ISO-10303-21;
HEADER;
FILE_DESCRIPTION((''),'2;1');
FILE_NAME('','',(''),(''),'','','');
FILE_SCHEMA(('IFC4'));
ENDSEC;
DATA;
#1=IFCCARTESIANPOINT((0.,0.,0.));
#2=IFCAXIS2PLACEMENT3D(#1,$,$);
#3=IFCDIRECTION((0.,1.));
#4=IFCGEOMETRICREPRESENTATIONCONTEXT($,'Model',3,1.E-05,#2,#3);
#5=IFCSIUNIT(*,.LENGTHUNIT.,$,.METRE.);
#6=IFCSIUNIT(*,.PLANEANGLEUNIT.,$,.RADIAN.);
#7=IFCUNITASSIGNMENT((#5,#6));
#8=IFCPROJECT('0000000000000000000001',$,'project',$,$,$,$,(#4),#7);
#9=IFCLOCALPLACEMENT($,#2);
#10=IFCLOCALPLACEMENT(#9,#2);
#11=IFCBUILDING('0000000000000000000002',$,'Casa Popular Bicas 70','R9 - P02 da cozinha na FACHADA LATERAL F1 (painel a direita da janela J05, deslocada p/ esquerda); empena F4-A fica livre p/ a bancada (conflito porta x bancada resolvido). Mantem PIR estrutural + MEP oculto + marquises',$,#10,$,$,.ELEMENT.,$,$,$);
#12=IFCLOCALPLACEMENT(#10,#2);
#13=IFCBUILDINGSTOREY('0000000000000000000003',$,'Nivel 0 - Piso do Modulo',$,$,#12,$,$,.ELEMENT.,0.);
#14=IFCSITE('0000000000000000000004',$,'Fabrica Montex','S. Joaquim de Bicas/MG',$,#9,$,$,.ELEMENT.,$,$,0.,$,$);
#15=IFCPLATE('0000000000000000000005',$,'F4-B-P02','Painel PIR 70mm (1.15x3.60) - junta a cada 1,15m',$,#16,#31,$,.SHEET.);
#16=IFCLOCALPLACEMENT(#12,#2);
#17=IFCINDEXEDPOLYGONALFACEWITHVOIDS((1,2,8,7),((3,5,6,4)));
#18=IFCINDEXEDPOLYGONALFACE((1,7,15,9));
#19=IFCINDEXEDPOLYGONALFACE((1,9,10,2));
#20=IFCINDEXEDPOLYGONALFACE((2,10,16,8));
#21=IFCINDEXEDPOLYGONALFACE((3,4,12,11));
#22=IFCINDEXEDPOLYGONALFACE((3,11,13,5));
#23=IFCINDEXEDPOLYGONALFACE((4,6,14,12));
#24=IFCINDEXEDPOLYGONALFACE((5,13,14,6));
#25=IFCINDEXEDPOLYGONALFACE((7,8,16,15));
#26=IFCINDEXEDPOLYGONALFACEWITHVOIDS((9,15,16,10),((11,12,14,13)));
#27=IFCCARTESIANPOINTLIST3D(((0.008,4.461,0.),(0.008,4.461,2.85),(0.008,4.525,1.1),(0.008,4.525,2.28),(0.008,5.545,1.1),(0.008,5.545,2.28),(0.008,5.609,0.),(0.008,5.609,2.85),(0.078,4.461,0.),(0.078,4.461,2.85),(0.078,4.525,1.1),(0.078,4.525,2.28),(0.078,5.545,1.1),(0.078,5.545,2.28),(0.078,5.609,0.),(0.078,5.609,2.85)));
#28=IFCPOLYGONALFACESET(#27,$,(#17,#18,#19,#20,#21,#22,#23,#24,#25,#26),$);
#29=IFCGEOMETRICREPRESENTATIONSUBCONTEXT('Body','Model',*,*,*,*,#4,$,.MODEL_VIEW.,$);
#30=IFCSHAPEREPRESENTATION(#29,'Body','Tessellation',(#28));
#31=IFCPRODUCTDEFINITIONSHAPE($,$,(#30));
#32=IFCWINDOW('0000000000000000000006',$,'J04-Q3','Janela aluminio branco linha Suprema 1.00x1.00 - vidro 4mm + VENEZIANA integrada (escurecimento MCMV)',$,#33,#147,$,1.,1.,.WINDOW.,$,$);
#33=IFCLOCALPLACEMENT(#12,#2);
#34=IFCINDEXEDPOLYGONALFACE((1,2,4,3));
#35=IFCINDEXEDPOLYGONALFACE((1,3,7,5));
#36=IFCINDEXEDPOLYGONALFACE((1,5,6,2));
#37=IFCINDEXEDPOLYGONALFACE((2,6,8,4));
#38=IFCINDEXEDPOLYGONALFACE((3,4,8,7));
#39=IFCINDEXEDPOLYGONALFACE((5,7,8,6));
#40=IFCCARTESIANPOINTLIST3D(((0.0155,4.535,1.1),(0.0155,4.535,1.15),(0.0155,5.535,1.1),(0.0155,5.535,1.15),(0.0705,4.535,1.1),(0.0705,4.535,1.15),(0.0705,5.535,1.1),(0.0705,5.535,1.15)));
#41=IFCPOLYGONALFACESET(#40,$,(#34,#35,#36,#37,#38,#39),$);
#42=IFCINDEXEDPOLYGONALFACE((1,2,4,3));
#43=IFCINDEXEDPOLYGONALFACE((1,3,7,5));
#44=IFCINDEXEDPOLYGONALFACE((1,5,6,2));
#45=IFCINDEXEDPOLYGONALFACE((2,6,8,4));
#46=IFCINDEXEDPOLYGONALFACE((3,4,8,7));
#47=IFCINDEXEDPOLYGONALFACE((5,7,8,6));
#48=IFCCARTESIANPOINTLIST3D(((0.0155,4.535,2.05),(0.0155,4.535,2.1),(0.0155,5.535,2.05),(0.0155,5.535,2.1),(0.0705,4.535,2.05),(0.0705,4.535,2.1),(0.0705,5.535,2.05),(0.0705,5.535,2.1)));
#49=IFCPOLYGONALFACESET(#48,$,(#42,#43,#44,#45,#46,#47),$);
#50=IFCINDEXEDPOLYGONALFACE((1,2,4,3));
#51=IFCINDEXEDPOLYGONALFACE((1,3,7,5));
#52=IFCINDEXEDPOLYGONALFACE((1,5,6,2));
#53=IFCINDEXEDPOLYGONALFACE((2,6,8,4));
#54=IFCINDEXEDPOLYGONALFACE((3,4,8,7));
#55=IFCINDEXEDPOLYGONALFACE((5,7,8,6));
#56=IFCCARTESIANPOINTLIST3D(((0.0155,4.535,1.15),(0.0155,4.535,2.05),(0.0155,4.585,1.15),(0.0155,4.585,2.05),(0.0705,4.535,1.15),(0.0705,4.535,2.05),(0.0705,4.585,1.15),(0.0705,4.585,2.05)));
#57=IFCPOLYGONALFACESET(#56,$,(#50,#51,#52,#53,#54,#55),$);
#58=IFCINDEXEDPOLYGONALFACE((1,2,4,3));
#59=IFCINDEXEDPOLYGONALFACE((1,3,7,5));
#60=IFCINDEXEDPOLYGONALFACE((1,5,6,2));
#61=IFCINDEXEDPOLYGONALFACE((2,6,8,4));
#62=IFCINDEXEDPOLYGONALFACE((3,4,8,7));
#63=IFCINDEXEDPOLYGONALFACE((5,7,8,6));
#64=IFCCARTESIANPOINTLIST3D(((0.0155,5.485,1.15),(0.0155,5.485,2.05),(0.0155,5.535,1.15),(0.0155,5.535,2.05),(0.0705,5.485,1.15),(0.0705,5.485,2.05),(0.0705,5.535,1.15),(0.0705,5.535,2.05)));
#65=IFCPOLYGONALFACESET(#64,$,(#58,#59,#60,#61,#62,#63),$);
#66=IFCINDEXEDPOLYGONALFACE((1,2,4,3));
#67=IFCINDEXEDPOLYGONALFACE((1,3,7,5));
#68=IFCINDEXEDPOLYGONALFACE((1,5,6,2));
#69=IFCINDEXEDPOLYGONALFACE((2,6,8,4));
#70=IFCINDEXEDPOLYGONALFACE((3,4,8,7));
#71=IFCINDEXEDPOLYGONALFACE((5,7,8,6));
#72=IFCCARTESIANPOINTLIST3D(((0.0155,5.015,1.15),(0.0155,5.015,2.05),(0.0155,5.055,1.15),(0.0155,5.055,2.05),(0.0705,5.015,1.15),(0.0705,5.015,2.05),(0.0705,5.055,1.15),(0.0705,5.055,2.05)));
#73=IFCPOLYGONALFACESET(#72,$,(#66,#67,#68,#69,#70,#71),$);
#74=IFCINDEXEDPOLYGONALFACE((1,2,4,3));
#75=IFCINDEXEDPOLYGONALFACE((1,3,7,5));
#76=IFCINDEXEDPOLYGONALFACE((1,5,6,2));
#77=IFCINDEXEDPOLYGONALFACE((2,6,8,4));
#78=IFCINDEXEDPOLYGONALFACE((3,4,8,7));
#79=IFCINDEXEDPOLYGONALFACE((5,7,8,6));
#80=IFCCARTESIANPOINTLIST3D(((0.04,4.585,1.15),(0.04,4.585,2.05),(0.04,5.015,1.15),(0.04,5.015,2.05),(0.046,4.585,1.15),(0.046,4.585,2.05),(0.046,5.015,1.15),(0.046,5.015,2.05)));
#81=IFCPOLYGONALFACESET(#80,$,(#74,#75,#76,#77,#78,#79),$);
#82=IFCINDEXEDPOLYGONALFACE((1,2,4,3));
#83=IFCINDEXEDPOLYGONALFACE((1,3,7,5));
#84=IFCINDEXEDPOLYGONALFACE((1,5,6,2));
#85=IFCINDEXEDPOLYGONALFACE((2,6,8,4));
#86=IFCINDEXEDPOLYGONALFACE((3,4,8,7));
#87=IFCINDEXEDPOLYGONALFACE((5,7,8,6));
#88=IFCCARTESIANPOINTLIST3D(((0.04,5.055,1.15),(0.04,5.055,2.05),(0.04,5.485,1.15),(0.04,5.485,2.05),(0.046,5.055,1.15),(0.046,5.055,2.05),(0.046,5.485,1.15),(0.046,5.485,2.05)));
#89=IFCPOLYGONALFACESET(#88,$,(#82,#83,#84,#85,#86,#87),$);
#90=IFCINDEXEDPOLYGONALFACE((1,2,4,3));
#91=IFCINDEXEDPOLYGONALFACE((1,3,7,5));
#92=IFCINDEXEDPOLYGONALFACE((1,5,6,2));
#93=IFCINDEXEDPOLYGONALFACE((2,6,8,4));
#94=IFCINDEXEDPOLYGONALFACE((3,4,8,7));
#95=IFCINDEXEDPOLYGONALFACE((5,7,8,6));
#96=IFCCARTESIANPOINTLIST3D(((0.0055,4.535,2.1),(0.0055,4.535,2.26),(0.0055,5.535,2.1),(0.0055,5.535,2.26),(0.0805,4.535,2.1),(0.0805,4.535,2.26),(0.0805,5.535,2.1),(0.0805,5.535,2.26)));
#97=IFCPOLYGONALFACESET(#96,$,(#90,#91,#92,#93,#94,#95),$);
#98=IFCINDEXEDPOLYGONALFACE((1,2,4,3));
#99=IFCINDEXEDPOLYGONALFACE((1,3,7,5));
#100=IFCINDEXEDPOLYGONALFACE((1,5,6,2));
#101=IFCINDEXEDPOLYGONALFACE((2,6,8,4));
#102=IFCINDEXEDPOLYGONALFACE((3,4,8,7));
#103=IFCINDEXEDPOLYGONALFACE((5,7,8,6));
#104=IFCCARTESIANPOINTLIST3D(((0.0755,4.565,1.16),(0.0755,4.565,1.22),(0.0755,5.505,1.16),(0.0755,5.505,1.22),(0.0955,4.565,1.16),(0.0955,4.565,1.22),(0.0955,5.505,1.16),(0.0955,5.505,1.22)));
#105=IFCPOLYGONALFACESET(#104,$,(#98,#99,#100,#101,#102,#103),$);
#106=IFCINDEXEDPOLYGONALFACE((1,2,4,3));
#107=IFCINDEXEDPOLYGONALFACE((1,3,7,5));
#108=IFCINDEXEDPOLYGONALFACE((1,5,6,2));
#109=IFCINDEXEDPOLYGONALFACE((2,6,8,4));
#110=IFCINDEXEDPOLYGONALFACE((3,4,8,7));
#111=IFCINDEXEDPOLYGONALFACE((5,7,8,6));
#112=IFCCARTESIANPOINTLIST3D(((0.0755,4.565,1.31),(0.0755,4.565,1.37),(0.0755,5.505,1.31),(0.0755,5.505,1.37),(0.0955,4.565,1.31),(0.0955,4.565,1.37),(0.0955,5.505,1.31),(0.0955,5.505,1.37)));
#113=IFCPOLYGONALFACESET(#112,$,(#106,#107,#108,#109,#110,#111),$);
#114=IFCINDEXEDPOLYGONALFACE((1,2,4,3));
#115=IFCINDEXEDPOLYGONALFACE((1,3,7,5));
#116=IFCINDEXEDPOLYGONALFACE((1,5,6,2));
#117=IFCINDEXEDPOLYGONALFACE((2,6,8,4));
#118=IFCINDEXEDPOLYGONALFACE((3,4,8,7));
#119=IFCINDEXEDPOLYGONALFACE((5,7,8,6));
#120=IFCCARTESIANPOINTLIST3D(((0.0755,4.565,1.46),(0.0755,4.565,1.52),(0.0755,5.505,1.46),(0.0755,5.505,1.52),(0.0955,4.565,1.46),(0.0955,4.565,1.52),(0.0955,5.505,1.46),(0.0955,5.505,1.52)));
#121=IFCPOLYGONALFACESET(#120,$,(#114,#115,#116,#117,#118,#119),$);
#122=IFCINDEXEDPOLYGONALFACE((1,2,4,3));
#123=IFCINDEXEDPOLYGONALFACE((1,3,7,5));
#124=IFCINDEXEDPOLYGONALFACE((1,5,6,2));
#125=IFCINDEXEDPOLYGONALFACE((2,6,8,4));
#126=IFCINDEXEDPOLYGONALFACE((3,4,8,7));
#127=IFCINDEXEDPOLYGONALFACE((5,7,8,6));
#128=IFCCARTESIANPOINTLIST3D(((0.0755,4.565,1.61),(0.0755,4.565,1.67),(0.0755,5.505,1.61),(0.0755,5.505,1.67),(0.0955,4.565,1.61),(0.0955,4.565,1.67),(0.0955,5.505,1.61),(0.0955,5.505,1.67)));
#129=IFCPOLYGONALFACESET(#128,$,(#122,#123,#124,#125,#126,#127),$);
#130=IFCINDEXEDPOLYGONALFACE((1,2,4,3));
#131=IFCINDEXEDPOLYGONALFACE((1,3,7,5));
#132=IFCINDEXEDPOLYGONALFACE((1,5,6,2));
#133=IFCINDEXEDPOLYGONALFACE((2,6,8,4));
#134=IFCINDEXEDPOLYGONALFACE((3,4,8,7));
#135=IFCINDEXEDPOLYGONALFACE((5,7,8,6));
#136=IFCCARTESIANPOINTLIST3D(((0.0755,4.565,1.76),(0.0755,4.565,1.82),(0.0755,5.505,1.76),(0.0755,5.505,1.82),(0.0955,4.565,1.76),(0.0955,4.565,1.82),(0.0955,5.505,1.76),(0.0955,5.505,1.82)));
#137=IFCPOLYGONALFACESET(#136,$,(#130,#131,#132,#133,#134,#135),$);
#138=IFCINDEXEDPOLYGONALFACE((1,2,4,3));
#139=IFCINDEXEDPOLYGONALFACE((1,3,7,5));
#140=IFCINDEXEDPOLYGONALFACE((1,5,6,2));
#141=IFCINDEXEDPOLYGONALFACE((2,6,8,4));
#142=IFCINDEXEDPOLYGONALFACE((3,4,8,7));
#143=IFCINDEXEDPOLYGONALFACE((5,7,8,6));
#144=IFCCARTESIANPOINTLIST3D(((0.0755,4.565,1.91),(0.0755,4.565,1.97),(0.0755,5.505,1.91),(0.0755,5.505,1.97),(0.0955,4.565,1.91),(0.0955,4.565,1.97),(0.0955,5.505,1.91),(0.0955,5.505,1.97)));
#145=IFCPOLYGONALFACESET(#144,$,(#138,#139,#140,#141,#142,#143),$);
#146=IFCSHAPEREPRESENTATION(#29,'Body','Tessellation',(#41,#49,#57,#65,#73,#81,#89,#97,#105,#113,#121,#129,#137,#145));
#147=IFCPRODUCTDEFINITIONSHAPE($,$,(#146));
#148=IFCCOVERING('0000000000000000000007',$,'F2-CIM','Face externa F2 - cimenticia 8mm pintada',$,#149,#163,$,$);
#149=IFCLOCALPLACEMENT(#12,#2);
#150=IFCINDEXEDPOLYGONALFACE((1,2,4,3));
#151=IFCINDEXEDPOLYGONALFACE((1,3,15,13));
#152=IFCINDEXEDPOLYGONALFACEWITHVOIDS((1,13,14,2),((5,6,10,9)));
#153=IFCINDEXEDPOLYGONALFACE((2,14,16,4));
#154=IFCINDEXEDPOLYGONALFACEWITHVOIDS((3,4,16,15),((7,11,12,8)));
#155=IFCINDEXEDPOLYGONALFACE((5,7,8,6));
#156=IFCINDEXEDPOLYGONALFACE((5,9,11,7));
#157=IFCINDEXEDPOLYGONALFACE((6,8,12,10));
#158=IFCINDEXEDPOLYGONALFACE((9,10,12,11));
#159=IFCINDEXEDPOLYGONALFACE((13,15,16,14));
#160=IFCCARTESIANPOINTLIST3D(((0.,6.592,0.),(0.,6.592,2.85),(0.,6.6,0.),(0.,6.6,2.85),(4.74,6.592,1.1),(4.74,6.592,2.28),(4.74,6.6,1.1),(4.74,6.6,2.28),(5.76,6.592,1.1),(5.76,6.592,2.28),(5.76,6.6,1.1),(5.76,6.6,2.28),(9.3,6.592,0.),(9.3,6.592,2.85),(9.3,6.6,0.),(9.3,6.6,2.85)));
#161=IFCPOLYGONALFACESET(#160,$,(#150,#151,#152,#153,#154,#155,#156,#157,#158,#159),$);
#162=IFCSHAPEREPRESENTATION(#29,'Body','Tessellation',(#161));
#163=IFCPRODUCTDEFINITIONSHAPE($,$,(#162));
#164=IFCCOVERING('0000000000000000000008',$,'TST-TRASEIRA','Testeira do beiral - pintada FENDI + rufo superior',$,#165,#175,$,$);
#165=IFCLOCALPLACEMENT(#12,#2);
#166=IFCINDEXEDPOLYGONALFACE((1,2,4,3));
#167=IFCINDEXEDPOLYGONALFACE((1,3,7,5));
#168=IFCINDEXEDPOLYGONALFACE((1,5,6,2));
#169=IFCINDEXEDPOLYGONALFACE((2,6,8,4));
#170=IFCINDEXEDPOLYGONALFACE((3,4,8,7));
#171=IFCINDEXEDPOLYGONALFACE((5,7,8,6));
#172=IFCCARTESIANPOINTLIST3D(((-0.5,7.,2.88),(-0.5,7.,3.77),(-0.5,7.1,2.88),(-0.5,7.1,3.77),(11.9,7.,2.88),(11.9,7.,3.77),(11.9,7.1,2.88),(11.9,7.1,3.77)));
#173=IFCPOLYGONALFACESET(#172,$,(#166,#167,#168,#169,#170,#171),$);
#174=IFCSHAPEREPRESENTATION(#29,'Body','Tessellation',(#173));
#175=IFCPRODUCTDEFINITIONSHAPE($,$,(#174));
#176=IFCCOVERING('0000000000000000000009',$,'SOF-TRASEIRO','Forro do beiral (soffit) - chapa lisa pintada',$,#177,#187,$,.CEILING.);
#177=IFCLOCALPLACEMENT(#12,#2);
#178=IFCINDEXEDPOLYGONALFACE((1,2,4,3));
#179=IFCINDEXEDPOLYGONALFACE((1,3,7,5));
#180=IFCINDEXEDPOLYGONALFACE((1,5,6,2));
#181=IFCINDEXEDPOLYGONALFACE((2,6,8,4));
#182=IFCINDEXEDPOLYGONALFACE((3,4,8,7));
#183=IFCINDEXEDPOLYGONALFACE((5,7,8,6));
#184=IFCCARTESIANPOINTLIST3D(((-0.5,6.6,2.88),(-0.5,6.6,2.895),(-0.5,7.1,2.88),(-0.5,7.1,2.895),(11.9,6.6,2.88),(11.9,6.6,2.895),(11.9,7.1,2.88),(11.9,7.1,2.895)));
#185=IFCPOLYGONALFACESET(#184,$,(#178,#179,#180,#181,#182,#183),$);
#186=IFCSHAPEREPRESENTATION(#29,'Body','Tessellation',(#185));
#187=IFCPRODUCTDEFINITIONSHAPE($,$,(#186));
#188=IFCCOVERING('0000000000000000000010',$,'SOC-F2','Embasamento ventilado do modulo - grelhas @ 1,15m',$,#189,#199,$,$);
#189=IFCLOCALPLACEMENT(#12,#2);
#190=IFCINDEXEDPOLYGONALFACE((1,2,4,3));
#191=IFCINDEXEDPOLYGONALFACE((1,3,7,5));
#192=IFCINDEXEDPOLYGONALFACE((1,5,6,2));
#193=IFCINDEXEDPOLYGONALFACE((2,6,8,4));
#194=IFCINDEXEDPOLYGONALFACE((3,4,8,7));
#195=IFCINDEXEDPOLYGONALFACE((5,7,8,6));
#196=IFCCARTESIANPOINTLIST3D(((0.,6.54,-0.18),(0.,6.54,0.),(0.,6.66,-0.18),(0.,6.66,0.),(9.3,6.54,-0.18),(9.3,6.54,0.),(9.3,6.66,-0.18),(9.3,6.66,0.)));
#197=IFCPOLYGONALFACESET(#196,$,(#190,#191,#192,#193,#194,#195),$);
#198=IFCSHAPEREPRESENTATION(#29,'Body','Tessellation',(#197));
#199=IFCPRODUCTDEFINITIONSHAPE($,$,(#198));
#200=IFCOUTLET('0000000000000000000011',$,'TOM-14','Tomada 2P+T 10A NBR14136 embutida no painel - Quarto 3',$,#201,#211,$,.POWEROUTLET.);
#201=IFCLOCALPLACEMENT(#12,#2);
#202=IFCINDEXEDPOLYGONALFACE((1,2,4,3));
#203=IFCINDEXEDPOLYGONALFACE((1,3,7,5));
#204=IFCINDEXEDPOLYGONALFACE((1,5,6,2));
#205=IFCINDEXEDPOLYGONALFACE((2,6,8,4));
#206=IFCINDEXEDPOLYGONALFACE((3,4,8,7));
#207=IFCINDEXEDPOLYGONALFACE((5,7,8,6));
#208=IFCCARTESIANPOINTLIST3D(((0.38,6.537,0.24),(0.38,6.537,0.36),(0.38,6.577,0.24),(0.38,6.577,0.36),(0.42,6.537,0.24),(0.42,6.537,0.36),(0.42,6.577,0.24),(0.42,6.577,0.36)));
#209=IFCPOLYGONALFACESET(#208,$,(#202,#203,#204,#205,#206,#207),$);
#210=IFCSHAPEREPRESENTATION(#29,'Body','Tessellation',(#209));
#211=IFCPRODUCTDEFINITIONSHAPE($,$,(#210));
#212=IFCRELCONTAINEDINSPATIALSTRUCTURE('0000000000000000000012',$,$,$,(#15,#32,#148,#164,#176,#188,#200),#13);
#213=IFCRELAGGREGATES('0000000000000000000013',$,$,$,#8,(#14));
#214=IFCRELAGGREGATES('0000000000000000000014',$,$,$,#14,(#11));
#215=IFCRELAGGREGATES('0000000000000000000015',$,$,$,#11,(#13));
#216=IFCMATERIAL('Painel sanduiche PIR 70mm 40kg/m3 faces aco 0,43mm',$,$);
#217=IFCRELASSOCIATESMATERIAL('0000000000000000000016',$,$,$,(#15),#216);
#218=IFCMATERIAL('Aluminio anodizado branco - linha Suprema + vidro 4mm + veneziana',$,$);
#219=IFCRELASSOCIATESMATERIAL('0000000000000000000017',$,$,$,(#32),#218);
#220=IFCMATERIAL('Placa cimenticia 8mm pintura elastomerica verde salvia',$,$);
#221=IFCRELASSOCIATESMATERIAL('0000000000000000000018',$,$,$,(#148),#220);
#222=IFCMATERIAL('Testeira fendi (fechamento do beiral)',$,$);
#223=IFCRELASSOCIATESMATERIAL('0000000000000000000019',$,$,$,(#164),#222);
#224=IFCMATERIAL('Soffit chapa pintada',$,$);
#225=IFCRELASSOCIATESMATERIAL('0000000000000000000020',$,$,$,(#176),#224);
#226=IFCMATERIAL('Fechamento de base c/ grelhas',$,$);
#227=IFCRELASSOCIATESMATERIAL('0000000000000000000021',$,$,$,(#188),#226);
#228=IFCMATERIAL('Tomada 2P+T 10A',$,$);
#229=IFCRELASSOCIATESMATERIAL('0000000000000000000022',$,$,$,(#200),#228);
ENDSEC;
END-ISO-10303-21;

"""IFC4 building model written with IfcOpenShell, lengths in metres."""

from ifc_helpers import new_model, si_unit, direction, frame, frame_2d, origin, place, context, subcontext, project, spatial, rectangle, extrude, material, element, fill, save


model = new_model("IFC4")

# Units and contexts
model_context = context("Model", 3, precision=1e-05, world=origin(), true_north=direction((0.0, 1.0)))
body_context = subcontext(model_context, "Body", "Model", "MODEL_VIEW")
ifc_project = project(units=[si_unit("LENGTHUNIT", "METRE"), si_unit("PLANEANGLEUNIT", "RADIAN")], contexts=[model_context])

# Site, building, storey
site_placement = place(None, origin())
site = spatial("IfcSite", under=ifc_project, at=site_placement, Name="Fabrica Montex", Description="S. Joaquim de Bicas/MG", CompositionType="ELEMENT", RefElevation=0.0)
building_placement = place(site_placement, origin())
building = spatial("IfcBuilding", under=site, at=building_placement, Name="Casa Popular Bicas 70", Description="R9 - P02 da cozinha na FACHADA LATERAL F1 (painel a direita da janela J05, deslocada p/ esquerda); empena F4-A fica livre p/ a bancada (conflito porta x bancada resolvido). Mantem PIR estrutural + MEP oculto + marquises", CompositionType="ELEMENT")
storey_placement = place(building_placement, origin())
storey = spatial("IfcBuildingStorey", under=building, at=storey_placement, Name="Nivel 0 - Piso do Modulo", CompositionType="ELEMENT", Elevation=0.0)

# Shared definitions
ifc_material_1 = material(Name="Painel sanduiche PIR 70mm 40kg/m3 faces aco 0,43mm")

# Plate, opening, window
plate_1_placement = place(storey_placement, frame((0.043, 4.461, 0.0), x_axis=(0.0, 1.0, 0.0)))
plate_1 = element("IfcPlate", 1, at=plate_1_placement, inside=storey, material=ifc_material_1, Name="F4-B-P02", Description="Painel PIR 70mm (1.15x3.60) - junta a cada 1,15m", PredefinedType="SHEET", context=body_context, shape_type="SweptSolid", body=[
    extrude(rectangle(XDim=1.148, YDim=0.07, at=frame_2d((0.574, 0.0))), origin(), (0.0, 0.0, 1.0), 2.85),
])
opening_1_placement = place(storey_placement, frame((0.043, 4.535, 1.1), x_axis=(0.0, 1.0, 0.0)))
opening_1 = element("IfcOpeningElement", 2, at=opening_1_placement, cuts=plate_1, PredefinedType="OPENING", context=body_context, shape_type="SweptSolid", body=[
    extrude(rectangle(XDim=1.02, YDim=0.3, at=frame_2d((0.5, 0.0))), origin(), (0.0, 0.0, 1.0), 1.18),
])
ifc_material_2 = material(Name="Aluminio anodizado branco - linha Suprema + vidro 4mm + veneziana")
window_placement = place(storey_placement, frame((0.043, 4.535, 1.1), x_axis=(0.0, 1.0, 0.0)))
window = element("IfcWindow", 3, at=window_placement, inside=storey, material=ifc_material_2, Name="J04-Q3", Description="Janela aluminio branco linha Suprema 1.00x1.00 - vidro 4mm + VENEZIANA integrada (escurecimento MCMV)", OverallHeight=1.0, OverallWidth=1.0, PredefinedType="WINDOW", context=body_context, shape_type="SweptSolid", body=[
    extrude(rectangle(XDim=1.0, YDim=0.055, at=frame_2d((0.5, 0.0))), origin(), (0.0, 0.0, 1.0), 0.05),
    extrude(rectangle(XDim=1.0, YDim=0.055, at=frame_2d((0.5, 0.0))), frame((0.0, 0.0, 0.95)), (0.0, 0.0, 1.0), 0.05),
    extrude(rectangle(XDim=0.05, YDim=0.055, at=frame_2d((0.025, 0.0))), frame((0.0, 0.0, 0.05)), (0.0, 0.0, 1.0), 0.9),
    extrude(rectangle(XDim=0.05, YDim=0.055, at=frame_2d((0.975, 0.0))), frame((0.0, 0.0, 0.05)), (0.0, 0.0, 1.0), 0.9),
    extrude(rectangle(XDim=0.04, YDim=0.055, at=frame_2d((0.5, 0.0))), frame((0.0, 0.0, 0.05)), (0.0, 0.0, 1.0), 0.9),
    extrude(rectangle(XDim=0.43, YDim=0.006, at=frame_2d((0.265, 0.0))), frame((0.0, 0.0, 0.05)), (0.0, 0.0, 1.0), 0.9),
    extrude(rectangle(XDim=0.43, YDim=0.006, at=frame_2d((0.735, 0.0))), frame((0.0, 0.0, 0.05)), (0.0, 0.0, 1.0), 0.9),
    extrude(rectangle(XDim=1.0, YDim=0.075, at=frame_2d((0.5, 0.0))), frame((0.0, 0.0, 1.0)), (0.0, 0.0, 1.0), 0.16),
    extrude(rectangle(XDim=0.94, YDim=0.02, at=frame_2d((0.5, -0.0425))), frame((0.0, 0.0, 0.06)), (0.0, 0.0, 1.0), 0.06),
    extrude(rectangle(XDim=0.94, YDim=0.02, at=frame_2d((0.5, -0.0425))), frame((0.0, 0.0, 0.21)), (0.0, 0.0, 1.0), 0.06),
    extrude(rectangle(XDim=0.94, YDim=0.02, at=frame_2d((0.5, -0.0425))), frame((0.0, 0.0, 0.36)), (0.0, 0.0, 1.0), 0.06),
    extrude(rectangle(XDim=0.94, YDim=0.02, at=frame_2d((0.5, -0.0425))), frame((0.0, 0.0, 0.51)), (0.0, 0.0, 1.0), 0.06),
    extrude(rectangle(XDim=0.94, YDim=0.02, at=frame_2d((0.5, -0.0425))), frame((0.0, 0.0, 0.66)), (0.0, 0.0, 1.0), 0.06),
    extrude(rectangle(XDim=0.94, YDim=0.02, at=frame_2d((0.5, -0.0425))), frame((0.0, 0.0, 0.81)), (0.0, 0.0, 1.0), 0.06),
])
fill(opening_1, window)

# Covering, opening
ifc_material_3 = material(Name="Placa cimenticia 8mm pintura elastomerica verde salvia")
covering_1_placement = place(storey_placement, frame((0.0, 6.596, 0.0), x_axis=(1.0, 0.0, 0.0)))
covering_1 = element("IfcCovering", 4, at=covering_1_placement, inside=storey, material=ifc_material_3, Name="F2-CIM", Description="Face externa F2 - cimenticia 8mm pintada", context=body_context, shape_type="SweptSolid", body=[
    extrude(rectangle(XDim=9.3, YDim=0.008, at=frame_2d((4.65, 0.0))), origin(), (0.0, 0.0, 1.0), 2.85),
])
opening_2_placement = place(storey_placement, frame((4.75, 6.596, 1.1)))
element("IfcOpeningElement", 5, at=opening_2_placement, cuts=covering_1, PredefinedType="OPENING", context=body_context, shape_type="SweptSolid", body=[
    extrude(rectangle(XDim=1.02, YDim=0.03, at=frame_2d((0.5, 0.0))), origin(), (0.0, 0.0, 1.0), 1.18),
])

# Coverings
ifc_material_4 = material(Name="Testeira fendi (fechamento do beiral)")
covering_2_placement = place(storey_placement, frame((-0.5, 7.05, 2.88), x_axis=(1.0, 0.0, 0.0)))
element("IfcCovering", 6, at=covering_2_placement, inside=storey, material=ifc_material_4, Name="TST-TRASEIRA", Description="Testeira do beiral - pintada FENDI + rufo superior", context=body_context, shape_type="SweptSolid", body=[
    extrude(rectangle(XDim=12.4, YDim=0.1, at=frame_2d((6.2, 0.0))), origin(), (0.0, 0.0, 1.0), 0.89),
])
ifc_material_5 = material(Name="Soffit chapa pintada")
covering_3_placement = place(storey_placement, frame((-0.5, 6.6, 2.88)))
element("IfcCovering", 7, at=covering_3_placement, inside=storey, material=ifc_material_5, Name="SOF-TRASEIRO", Description="Forro do beiral (soffit) - chapa lisa pintada", PredefinedType="CEILING", context=body_context, shape_type="SweptSolid", body=[
    extrude(rectangle(XDim=12.4, YDim=0.5, at=frame_2d((6.2, 0.25))), origin(), (0.0, 0.0, 1.0), 0.015),
])
ifc_material_6 = material(Name="Fechamento de base c/ grelhas")
covering_4_placement = place(storey_placement, frame((0.0, 6.6, -0.18), x_axis=(1.0, 0.0, 0.0)))
element("IfcCovering", 8, at=covering_4_placement, inside=storey, material=ifc_material_6, Name="SOC-F2", Description="Embasamento ventilado do modulo - grelhas @ 1,15m", context=body_context, shape_type="SweptSolid", body=[
    extrude(rectangle(XDim=9.3, YDim=0.12, at=frame_2d((4.65, 0.0))), origin(), (0.0, 0.0, 1.0), 0.18),
])

# Outlet
ifc_material_7 = material(Name="Tomada 2P+T 10A")
outlet_1_placement = place(storey_placement, frame((0.38, 6.537, 0.24)))
element("IfcOutlet", 9, at=outlet_1_placement, inside=storey, material=ifc_material_7, Name="TOM-14", Description="Tomada 2P+T 10A NBR14136 embutida no painel - Quarto 3", PredefinedType="POWEROUTLET", context=body_context, shape_type="SweptSolid", body=[
    extrude(rectangle(XDim=0.04, YDim=0.04, at=frame_2d((0.02, 0.02))), origin(), (0.0, 0.0, 1.0), 0.12),
])

save(model, "model.ifc")
